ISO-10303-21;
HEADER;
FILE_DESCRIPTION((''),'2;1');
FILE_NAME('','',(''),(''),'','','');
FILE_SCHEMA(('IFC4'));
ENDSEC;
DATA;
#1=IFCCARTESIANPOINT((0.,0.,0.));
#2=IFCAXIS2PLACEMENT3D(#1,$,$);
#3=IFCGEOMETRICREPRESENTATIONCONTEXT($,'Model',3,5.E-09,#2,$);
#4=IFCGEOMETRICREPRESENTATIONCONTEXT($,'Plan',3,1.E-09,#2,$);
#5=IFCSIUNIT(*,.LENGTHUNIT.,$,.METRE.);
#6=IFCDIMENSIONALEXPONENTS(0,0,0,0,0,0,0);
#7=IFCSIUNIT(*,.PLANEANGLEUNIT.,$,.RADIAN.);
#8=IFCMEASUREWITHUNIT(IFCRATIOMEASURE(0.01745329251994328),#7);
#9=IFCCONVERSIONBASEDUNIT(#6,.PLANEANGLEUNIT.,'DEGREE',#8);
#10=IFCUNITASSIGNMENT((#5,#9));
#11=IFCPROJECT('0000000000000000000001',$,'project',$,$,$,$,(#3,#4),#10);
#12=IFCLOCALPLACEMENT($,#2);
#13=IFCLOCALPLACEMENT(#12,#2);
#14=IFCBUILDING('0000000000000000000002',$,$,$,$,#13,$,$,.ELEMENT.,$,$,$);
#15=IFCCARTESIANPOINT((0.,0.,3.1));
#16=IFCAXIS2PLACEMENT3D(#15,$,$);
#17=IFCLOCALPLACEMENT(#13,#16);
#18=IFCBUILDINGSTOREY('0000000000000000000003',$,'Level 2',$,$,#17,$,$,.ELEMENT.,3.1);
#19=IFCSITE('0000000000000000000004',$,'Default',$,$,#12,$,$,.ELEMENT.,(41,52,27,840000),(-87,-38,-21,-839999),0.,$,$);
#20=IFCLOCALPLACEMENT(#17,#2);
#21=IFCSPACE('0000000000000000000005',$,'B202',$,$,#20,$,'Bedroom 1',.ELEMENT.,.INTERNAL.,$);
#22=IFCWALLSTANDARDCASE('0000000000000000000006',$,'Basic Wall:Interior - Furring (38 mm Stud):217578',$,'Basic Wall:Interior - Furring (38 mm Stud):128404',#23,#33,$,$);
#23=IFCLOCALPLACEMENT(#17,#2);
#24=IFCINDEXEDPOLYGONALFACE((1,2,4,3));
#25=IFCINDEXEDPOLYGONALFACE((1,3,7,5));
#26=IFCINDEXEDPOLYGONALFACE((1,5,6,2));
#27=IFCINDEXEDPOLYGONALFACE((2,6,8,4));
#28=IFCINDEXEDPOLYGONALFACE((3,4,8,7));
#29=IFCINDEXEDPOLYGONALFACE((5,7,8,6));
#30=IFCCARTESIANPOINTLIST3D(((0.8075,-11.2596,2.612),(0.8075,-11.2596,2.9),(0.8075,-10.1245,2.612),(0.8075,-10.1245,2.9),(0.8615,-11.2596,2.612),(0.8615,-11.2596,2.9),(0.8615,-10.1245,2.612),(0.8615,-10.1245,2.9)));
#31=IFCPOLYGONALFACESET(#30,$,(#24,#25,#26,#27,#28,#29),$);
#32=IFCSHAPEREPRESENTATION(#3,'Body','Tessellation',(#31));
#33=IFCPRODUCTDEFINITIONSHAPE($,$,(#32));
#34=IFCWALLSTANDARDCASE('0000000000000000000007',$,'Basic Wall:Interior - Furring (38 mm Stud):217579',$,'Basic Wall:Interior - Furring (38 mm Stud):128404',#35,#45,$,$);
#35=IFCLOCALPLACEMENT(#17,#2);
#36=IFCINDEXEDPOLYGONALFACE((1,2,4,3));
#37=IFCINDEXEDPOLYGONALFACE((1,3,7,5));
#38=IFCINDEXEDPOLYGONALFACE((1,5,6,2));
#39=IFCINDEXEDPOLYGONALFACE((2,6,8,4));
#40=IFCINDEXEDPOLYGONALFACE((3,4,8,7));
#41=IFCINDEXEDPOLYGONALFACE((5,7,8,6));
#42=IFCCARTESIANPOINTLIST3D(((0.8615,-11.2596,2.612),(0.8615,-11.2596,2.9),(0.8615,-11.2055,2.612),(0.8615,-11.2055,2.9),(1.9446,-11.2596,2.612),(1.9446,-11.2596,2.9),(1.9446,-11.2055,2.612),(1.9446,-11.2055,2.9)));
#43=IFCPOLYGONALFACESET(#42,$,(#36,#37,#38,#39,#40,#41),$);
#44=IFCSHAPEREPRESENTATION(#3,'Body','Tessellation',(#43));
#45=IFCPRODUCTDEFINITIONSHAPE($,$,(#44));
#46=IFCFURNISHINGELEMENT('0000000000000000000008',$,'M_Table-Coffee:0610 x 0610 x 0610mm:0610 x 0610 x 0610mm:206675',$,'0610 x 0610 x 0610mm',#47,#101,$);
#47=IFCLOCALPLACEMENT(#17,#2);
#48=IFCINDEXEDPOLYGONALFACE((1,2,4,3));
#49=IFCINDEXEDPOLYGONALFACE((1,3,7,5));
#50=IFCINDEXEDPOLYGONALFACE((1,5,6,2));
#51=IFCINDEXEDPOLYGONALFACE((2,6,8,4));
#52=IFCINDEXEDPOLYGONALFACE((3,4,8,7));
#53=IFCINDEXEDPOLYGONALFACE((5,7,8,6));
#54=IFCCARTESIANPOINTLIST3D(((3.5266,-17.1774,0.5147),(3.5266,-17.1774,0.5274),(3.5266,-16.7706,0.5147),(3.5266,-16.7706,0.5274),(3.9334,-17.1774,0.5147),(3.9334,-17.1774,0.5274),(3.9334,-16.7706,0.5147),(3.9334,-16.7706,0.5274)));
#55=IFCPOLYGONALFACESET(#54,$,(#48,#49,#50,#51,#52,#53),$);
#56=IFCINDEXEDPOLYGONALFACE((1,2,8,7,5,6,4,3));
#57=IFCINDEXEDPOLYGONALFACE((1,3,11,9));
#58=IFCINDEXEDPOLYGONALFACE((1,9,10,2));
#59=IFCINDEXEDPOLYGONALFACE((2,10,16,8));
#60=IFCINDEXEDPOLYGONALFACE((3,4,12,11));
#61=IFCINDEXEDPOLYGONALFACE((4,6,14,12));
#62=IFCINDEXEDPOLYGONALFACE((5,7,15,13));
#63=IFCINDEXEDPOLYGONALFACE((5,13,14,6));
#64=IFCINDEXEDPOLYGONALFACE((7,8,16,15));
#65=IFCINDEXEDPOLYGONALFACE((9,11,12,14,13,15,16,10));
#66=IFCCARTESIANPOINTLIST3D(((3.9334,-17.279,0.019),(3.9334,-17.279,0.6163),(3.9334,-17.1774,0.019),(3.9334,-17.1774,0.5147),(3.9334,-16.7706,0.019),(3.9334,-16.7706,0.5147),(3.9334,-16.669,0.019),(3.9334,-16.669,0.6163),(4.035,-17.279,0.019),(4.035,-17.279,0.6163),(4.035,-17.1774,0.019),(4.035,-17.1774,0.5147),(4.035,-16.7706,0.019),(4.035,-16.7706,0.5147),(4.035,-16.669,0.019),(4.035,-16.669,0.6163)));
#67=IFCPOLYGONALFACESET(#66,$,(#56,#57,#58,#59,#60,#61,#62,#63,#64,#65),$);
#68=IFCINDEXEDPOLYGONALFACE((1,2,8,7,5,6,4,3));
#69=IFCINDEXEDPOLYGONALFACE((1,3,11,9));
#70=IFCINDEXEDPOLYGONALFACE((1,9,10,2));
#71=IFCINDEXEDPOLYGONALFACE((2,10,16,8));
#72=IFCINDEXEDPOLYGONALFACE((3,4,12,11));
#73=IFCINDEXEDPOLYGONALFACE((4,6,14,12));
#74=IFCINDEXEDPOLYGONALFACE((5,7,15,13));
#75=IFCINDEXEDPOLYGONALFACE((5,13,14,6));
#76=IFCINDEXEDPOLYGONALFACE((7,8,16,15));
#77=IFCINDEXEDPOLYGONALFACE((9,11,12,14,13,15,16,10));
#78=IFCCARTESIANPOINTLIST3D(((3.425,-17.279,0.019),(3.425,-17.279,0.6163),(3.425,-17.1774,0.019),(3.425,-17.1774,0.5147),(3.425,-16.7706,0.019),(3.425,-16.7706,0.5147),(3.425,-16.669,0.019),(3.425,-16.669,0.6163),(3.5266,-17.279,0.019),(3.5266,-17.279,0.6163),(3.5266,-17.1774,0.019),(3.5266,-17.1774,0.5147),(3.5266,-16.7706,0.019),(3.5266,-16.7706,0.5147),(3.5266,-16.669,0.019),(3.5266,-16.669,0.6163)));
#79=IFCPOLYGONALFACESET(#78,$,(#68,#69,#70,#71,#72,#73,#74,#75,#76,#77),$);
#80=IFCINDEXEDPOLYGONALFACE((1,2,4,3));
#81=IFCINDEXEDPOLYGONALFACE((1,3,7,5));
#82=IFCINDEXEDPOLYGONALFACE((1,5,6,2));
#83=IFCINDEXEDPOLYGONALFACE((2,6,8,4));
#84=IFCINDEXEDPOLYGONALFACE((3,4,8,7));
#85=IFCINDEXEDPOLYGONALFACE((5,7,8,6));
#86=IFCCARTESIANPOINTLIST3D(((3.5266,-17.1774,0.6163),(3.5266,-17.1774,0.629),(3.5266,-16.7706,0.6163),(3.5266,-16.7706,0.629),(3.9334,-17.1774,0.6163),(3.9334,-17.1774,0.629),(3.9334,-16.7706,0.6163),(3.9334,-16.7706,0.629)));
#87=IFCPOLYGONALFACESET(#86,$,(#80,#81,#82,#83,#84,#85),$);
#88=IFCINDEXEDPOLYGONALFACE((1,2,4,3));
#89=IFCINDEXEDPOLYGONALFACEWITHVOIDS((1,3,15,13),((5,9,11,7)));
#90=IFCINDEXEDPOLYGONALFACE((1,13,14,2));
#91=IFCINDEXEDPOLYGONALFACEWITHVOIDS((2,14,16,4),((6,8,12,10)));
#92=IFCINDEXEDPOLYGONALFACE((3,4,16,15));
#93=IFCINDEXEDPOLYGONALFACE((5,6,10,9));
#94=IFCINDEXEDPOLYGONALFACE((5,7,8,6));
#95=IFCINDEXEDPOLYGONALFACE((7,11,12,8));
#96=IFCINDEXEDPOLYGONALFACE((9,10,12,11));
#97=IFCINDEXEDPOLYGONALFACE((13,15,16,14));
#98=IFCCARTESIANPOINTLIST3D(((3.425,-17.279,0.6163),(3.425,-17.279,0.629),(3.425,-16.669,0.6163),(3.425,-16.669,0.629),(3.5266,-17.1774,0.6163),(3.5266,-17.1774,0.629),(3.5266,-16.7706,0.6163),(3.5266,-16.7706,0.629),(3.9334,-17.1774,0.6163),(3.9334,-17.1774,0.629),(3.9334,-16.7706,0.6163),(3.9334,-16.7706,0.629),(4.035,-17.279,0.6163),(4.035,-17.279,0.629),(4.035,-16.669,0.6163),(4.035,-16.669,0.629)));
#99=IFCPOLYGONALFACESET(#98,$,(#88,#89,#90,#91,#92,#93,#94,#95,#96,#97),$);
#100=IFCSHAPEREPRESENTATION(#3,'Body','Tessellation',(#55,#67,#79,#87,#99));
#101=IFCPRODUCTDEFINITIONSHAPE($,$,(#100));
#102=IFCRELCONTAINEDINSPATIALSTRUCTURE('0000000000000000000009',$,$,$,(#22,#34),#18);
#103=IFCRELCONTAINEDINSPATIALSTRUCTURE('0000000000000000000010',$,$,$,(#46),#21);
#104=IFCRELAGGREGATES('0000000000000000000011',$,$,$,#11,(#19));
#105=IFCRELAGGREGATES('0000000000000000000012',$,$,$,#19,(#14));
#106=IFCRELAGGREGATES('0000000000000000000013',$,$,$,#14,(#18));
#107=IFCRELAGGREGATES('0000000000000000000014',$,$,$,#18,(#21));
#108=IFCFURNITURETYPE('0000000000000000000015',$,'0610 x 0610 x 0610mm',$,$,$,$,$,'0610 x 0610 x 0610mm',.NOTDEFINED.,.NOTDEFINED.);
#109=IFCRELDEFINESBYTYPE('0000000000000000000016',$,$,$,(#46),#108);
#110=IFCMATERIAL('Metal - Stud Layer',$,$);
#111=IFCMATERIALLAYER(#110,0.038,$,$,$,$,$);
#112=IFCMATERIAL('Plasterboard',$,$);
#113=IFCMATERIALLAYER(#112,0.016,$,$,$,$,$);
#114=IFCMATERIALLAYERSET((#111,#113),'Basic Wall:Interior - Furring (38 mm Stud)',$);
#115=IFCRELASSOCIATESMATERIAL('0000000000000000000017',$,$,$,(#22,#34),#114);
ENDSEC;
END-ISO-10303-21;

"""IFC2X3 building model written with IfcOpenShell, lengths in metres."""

from ifc_helpers import new_model, entity, si_unit, converted_unit, frame, frame_2d, origin, origin_2d_with_axis, place, context, project, spatial, polyline, rectangle, outline, extrude, source, transform, mapped, material, layer, layer_set, layer_usage, type_object, type_shapes, element, save


model = new_model("IFC2X3")

# Units and contexts
model_context = context("Model", 3, precision=5e-09, world=origin())
plan_context = context("Plan", 3, precision=1e-09, world=origin())
ifc_project = project(units=[si_unit("LENGTHUNIT", "METRE"), converted_unit("PLANEANGLEUNIT", "DEGREE", entity("IfcRatioMeasure", 0.01745329251994328), si_unit("PLANEANGLEUNIT", "RADIAN"), dimensions=[0, 0, 0, 0, 0, 0, 0])], contexts=[model_context, plan_context])

# Site, building, storey
site_placement = place(None, origin())
site = spatial("IfcSite", under=ifc_project, at=site_placement, Name="Default", CompositionType="ELEMENT", RefLatitude=(41, 52, 27, 840000), RefLongitude=(-87, -38, -21, -839999), RefElevation=0.0)
building_placement = place(site_placement, origin())
building = spatial("IfcBuilding", under=site, at=building_placement, CompositionType="ELEMENT")
storey_placement = place(building_placement, frame((0.0, 0.0, 3.1)))
storey = spatial("IfcBuildingStorey", under=building, at=storey_placement, Name="Level 2", CompositionType="ELEMENT", Elevation=3.1)

# Shared definitions
ifc_material_1 = material(Name="Metal - Stud Layer")
ifc_material_2 = material(Name="Plasterboard")

# Walls
ifc_layer_1 = layer(ifc_material_1, 0.038)
ifc_layer_2 = layer(ifc_material_2, 0.016)
ifc_layer_set_1 = layer_set([ifc_layer_1, ifc_layer_2], Name="Basic Wall:Interior - Furring (38 mm Stud)")
ifc_layer_usage_1 = layer_usage(ifc_layer_set_1, "AXIS2", "NEGATIVE", 0.027)
wall_1_placement = place(storey_placement, frame((0.8345, -11.2596, 2.612), z_axis=(0.0, 0.0, 1.0), x_axis=(0.0, 1.0, 0.0)))
element("IfcWallStandardCase", 1, at=wall_1_placement, inside=storey, material=ifc_layer_usage_1, Name="Basic Wall:Interior - Furring (38 mm Stud):217578", ObjectType="Basic Wall:Interior - Furring (38 mm Stud):128404", context=model_context, shape_type="SweptSolid", body=[
    extrude(rectangle(XDim=1.1351, YDim=0.054, at=frame_2d((0.5675, 0.0), x_axis=(-1.0, 0.0))), origin(), (0.0, 0.0, 1.0), 0.288),
])
wall_2_placement = place(storey_placement, frame((1.9446, -11.2325, 2.612), z_axis=(0.0, 0.0, 1.0), x_axis=(-1.0, 0.0, 0.0)))
element("IfcWallStandardCase", 2, at=wall_2_placement, inside=storey, material=ifc_layer_usage_1, Name="Basic Wall:Interior - Furring (38 mm Stud):217579", ObjectType="Basic Wall:Interior - Furring (38 mm Stud):128404", context=model_context, shape_type="SweptSolid", body=[
    extrude(rectangle(XDim=1.0831, YDim=0.054, at=frame_2d((0.5415, 0.0), x_axis=(-1.0, 0.0))), origin(), (0.0, 0.0, 1.0), 0.288),
])

# Shared definitions
space_placement = place(storey_placement, origin())
space = spatial("IfcSpace", under=storey, at=space_placement, Name="B202", LongName="Bedroom 1", CompositionType="ELEMENT", InteriorOrExteriorSpace="INTERNAL")

# Furnishing element
furniture_type = type_object("IfcFurnitureType", Name="0610 x 0610 x 0610mm", ElementType="0610 x 0610 x 0610mm", AssemblyPlace="NOTDEFINED")
shared_shape_1 = source(origin(), model_context, "Body", "SweptSolid", [
    extrude(rectangle(XDim=0.4068, YDim=0.4068, at=origin_2d_with_axis()), frame((0.0183, 0.0952, 0.4957), z_axis=(0.0, 0.0, 1.0), x_axis=(-1.0, 0.0, 0.0)), (0.0, 0.0, 1.0), 0.0127),
    extrude(outline(polyline([(-0.2732, -0.305), (0.324, -0.305), (0.324, 0.305), (-0.2732, 0.305), (-0.2732, 0.2034), (0.2225, 0.2034), (0.2225, -0.2034), (-0.2732, -0.2034), (-0.2732, -0.305)])), frame((0.2217, 0.0952, 0.2732), z_axis=(1.0, 0.0, 0.0), x_axis=(0.0, 0.0, 1.0)), (0.0, 0.0, 1.0), 0.1016),
    extrude(outline(polyline([(-0.305, -0.3241), (0.305, -0.3241), (0.305, 0.2733), (0.2034, 0.2733), (0.2034, -0.2224), (-0.2034, -0.2224), (-0.2034, 0.2733), (-0.305, 0.2733), (-0.305, -0.3241)])), frame((-0.2867, 0.0952, 0.2733), z_axis=(1.0, 0.0, 0.0), x_axis=(0.0, -1.0, 0.0)), (0.0, 0.0, 1.0), 0.1016),
    extrude(rectangle(XDim=0.4068, YDim=0.4068, at=origin_2d_with_axis()), frame((0.0183, 0.0952, 0.5973), z_axis=(0.0, 0.0, 1.0), x_axis=(-1.0, 0.0, 0.0)), (0.0, 0.0, 1.0), 0.0127),
    extrude(outline(polyline([(-0.305, -0.305), (0.305, -0.305), (0.305, 0.305), (-0.305, 0.305), (-0.305, -0.305)]), holes=[polyline([(-0.2034, -0.2034), (-0.2034, 0.2034), (0.2034, 0.2034), (0.2034, -0.2034), (-0.2034, -0.2034)])]), frame((0.0183, 0.0952, 0.5973), z_axis=(0.0, 0.0, 1.0), x_axis=(-1.0, 0.0, 0.0)), (0.0, 0.0, 1.0), 0.0127),
])
type_shapes(furniture_type, [shared_shape_1])
furnishing_placement = place(space_placement, frame((3.7117, -17.0692, 0.019)))
element("IfcFurnishingElement", 3, at=furnishing_placement, inside=space, type_object=furniture_type, Name="M_Table-Coffee:0610 x 0610 x 0610mm:0610 x 0610 x 0610mm:206675", ObjectType="0610 x 0610 x 0610mm", context=model_context, shape_type="MappedRepresentation", body=[
    mapped(shared_shape_1, transform((0.0, 0.0, 0.0), scale=1.0)),
])

save(model, "model.ifc")
